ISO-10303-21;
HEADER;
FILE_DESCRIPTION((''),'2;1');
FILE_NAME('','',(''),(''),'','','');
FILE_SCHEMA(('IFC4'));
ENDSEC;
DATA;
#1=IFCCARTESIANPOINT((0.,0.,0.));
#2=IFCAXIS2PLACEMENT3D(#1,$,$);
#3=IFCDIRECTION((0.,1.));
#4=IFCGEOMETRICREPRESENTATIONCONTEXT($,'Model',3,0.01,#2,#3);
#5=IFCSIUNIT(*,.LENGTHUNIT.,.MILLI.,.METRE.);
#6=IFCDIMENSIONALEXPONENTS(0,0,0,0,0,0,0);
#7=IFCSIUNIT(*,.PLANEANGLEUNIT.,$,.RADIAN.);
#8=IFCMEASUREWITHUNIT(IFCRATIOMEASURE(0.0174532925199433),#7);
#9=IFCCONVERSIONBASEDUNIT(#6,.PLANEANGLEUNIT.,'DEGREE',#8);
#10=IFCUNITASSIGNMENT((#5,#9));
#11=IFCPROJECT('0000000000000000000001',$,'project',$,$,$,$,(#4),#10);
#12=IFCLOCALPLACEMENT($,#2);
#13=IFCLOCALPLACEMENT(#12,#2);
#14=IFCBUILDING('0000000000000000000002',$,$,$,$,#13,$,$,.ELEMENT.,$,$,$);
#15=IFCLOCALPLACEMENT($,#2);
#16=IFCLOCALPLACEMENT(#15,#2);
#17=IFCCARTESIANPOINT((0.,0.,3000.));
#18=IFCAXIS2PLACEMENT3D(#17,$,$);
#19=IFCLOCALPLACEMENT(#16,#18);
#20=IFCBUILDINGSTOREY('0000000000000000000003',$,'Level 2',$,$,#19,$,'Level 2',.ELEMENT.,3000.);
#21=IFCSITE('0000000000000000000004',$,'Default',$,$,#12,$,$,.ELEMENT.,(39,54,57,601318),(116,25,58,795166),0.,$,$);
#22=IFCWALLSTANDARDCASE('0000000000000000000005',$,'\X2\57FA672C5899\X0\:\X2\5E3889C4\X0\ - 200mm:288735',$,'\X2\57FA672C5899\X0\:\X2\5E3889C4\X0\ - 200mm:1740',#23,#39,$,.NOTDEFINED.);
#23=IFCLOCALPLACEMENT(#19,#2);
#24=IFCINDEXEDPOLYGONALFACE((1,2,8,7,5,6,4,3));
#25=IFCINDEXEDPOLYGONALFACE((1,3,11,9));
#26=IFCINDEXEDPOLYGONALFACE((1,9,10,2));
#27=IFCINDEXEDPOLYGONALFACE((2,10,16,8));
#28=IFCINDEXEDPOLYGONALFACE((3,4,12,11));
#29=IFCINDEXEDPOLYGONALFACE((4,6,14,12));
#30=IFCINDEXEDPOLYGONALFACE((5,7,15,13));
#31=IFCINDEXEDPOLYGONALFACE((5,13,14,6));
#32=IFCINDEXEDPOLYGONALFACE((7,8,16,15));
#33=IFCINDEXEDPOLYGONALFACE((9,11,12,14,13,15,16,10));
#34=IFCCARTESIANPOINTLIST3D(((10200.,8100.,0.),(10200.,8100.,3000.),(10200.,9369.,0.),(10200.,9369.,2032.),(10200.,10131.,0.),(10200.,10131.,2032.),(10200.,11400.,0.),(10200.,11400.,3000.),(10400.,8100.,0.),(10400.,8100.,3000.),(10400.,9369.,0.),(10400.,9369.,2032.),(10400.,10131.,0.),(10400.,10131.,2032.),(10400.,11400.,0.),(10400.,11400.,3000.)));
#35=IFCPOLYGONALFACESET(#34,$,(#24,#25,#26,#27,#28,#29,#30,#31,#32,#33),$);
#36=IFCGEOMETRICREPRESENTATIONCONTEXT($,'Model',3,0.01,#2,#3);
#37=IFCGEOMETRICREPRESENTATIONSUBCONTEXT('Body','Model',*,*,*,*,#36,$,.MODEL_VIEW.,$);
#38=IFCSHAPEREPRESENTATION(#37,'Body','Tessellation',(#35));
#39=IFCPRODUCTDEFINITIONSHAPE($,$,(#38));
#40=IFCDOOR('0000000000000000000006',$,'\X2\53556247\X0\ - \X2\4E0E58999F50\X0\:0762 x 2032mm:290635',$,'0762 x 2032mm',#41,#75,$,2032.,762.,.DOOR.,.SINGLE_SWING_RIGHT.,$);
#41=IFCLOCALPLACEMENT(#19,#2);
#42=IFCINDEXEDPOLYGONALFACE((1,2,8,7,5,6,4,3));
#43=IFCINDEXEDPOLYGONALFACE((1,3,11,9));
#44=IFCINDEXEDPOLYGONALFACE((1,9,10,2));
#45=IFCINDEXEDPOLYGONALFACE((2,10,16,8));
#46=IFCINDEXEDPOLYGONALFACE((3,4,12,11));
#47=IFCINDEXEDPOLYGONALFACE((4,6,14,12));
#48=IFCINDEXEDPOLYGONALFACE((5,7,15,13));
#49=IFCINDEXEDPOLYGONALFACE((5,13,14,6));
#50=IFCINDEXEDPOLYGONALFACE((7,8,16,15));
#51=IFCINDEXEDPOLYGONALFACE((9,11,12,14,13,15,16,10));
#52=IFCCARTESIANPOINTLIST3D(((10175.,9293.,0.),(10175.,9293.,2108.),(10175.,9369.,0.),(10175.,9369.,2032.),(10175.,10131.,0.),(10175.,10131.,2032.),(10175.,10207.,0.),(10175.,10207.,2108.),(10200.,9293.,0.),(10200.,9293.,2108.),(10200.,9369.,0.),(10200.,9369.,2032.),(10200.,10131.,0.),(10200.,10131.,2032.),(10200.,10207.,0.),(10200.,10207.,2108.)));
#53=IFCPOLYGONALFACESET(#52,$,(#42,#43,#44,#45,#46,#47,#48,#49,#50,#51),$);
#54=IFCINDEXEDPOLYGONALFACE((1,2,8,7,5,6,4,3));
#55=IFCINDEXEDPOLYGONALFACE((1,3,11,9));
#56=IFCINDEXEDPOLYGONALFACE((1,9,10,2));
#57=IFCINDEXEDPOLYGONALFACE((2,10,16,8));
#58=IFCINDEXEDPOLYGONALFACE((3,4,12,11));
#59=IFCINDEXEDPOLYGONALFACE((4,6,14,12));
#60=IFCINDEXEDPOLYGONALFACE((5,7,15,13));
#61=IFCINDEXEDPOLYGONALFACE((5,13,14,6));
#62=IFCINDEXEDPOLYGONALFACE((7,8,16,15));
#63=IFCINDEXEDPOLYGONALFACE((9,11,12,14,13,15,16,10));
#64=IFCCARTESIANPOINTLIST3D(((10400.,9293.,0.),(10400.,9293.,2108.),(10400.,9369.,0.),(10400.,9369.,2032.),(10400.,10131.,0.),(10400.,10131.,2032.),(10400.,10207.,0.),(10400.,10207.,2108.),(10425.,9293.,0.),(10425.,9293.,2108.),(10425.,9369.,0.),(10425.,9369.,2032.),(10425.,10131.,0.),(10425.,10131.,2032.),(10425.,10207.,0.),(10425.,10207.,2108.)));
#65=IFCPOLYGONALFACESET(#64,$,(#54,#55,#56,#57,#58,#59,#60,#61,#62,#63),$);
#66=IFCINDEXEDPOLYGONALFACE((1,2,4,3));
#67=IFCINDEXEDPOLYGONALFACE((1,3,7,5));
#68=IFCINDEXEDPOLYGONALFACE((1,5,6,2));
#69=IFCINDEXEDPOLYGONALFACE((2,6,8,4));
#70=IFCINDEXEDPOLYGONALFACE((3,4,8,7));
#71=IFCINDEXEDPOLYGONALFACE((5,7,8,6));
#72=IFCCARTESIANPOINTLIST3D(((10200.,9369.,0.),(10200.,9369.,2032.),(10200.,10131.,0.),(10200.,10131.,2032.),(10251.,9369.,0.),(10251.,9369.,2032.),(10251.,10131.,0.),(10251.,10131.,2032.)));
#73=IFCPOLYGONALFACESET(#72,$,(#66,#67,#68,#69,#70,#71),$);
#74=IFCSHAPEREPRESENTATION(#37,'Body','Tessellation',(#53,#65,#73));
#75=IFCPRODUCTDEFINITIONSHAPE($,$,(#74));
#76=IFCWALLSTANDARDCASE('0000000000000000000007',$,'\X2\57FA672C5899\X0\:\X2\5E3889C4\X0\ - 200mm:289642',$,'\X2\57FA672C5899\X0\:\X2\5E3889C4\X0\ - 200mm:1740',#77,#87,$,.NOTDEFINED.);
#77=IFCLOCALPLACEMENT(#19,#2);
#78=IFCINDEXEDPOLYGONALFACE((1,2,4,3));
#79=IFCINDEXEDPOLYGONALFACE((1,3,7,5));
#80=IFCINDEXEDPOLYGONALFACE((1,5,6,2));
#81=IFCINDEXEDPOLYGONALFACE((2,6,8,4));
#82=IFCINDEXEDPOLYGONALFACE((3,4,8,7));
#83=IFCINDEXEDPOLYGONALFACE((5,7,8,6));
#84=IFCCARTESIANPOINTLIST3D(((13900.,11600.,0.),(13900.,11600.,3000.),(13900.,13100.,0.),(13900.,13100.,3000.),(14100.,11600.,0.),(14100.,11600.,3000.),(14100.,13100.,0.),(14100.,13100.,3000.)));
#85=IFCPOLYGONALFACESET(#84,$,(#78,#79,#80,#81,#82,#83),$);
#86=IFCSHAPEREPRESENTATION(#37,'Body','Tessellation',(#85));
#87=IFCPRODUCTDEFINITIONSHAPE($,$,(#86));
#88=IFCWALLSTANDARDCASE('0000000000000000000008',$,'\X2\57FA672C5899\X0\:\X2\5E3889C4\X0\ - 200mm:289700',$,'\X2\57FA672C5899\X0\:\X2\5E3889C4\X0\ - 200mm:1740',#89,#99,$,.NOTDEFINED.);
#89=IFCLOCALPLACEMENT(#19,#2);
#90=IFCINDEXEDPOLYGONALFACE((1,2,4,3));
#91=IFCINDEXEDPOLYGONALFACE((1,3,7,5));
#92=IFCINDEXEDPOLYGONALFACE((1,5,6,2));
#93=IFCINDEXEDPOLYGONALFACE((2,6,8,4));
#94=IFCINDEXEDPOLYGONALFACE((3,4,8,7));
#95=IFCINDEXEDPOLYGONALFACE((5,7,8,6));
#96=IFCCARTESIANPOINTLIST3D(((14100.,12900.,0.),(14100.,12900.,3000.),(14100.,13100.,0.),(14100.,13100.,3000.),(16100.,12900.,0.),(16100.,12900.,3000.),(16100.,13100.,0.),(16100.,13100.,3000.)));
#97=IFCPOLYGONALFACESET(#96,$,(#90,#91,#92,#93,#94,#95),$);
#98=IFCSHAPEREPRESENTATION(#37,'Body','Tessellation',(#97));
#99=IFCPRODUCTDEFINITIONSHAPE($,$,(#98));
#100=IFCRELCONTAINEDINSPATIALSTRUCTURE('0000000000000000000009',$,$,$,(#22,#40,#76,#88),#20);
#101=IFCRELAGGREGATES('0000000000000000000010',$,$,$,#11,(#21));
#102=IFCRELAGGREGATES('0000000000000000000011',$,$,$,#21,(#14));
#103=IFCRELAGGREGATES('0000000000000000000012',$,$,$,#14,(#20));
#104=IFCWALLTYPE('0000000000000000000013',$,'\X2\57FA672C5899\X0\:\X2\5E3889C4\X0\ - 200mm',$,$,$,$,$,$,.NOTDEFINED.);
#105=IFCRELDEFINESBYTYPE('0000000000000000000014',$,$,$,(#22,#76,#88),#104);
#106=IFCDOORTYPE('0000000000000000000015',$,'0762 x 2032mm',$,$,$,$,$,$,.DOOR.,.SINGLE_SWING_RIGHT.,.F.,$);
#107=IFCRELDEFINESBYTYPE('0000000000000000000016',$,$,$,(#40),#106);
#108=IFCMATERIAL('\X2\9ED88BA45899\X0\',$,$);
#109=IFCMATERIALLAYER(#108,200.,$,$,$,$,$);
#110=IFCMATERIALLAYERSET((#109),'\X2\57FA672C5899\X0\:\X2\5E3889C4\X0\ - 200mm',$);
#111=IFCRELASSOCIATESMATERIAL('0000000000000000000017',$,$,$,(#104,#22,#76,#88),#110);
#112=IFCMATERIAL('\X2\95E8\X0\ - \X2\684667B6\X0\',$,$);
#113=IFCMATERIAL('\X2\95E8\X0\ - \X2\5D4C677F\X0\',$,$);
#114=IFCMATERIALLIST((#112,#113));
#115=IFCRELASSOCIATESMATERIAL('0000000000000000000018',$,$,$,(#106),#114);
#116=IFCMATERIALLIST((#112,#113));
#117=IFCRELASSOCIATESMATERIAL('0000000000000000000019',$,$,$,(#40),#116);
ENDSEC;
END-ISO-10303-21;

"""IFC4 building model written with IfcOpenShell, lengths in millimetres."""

from ifc_helpers import new_model, entity, si_unit, converted_unit, direction, frame, frame_2d, origin, place, context, subcontext, project, spatial, polyline, rectangle, outline, extrude, source, transform, mapped, material, material_list, layer, layer_set, layer_usage, type_object, type_shapes, element, fill, save


model = new_model("IFC4")

# Units and contexts
model_context_1 = context("Model", 3, precision=0.01, world=origin(), true_north=direction((0.0, 1.0)))
model_context_2 = context("Model", 3, precision=0.01, world=origin(), true_north=direction((0.0, 1.0)))
body_context = subcontext(model_context_2, "Body", "Model", "MODEL_VIEW")
ifc_project = project(units=[si_unit("LENGTHUNIT", "METRE", prefix="MILLI"), converted_unit("PLANEANGLEUNIT", "DEGREE", entity("IfcRatioMeasure", 0.0174532925199433), si_unit("PLANEANGLEUNIT", "RADIAN"), dimensions=[0, 0, 0, 0, 0, 0, 0])], contexts=[model_context_1])

# Site, building, storey
site_placement = place(None, origin())
site = spatial("IfcSite", under=ifc_project, at=site_placement, Name="Default", CompositionType="ELEMENT", RefLatitude=(39, 54, 57, 601318), RefLongitude=(116, 25, 58, 795166), RefElevation=0.0)
building_placement = place(site_placement, origin())
building = spatial("IfcBuilding", under=site, at=building_placement, CompositionType="ELEMENT")
placement_1 = place(None, origin())
placement_2 = place(placement_1, origin())
storey_placement = place(placement_2, frame((0.0, 0.0, 3000.0)))
storey = spatial("IfcBuildingStorey", under=building, at=storey_placement, Name="Level 2", LongName="Level 2", CompositionType="ELEMENT", Elevation=3000.0)

# Shared definitions
ifc_material_1 = material(Name="默认墙")
ifc_layer = layer(ifc_material_1, 200.0)
ifc_layer_set = layer_set([ifc_layer], Name="基本墙:常规 - 200mm")
wall_type = type_object("IfcWallType", Name="基本墙:常规 - 200mm", PredefinedType="NOTDEFINED", material=ifc_layer_set)

# Wall, opening, door
ifc_layer_usage_1 = layer_usage(ifc_layer_set, "AXIS2", "NEGATIVE", 100.0)
wall_1_placement = place(storey_placement, frame((10300.0, 11400.0, 0.0), z_axis=(0.0, 0.0, 1.0), x_axis=(0.0, -1.0, 0.0)))
wall_1 = element("IfcWallStandardCase", 1, at=wall_1_placement, inside=storey, type_object=wall_type, material=ifc_layer_usage_1, Name="基本墙:常规 - 200mm:288735", ObjectType="基本墙:常规 - 200mm:1740", PredefinedType="NOTDEFINED", context=body_context, shape_type="SweptSolid", body=[
    extrude(rectangle(XDim=3300.0, YDim=200.0, at=frame_2d((1650.0, 0.0), x_axis=(-1.0, 0.0))), origin(), (0.0, 0.0, 1.0), 3000.0),
])
opening_1_placement = place(wall_1_placement, frame((2031.0, 100.0, 0.0)))
opening_1 = element("IfcOpeningElement", 2, at=opening_1_placement, cuts=wall_1, ObjectType="Opening", PredefinedType="OPENING", context=body_context, shape_type="SweptSolid", body=[
    extrude(rectangle(XDim=762.0, YDim=2032.0, at=frame_2d((1016.0, 381.0), x_axis=(0.0, 1.0))), frame((0.0, 0.0, 0.0), z_axis=(0.0, -1.0, 0.0), x_axis=(0.0, 0.0, 1.0)), (0.0, 0.0, 1.0), 200.0),
])
ifc_material_2 = material(Name="门 - 框架")
ifc_material_3 = material(Name="门 - 嵌板")
ifc_material_list_1 = material_list([ifc_material_2, ifc_material_3])
ifc_material_list_2 = material_list([ifc_material_2, ifc_material_3])
door_type_1 = type_object("IfcDoorType", Name="0762 x 2032mm", OperationType="SINGLE_SWING_RIGHT", ParameterTakesPrecedence=False, PredefinedType="DOOR", material=ifc_material_list_2)
shared_shape_1 = source(origin(), body_context, "Body", "SweptSolid", [
    extrude(outline(polyline([(-457.0, -1073.0), (457.0, -1073.0), (457.0, 1035.0), (381.0, 1035.0), (381.0, -997.0), (-381.0, -997.0), (-381.0, 1035.0), (-457.0, 1035.0), (-457.0, -1073.0)])), frame((381.0, 200.0, 1035.0), z_axis=(0.0, 1.0, 0.0), x_axis=(1.0, 0.0, 0.0)), (0.0, 0.0, 1.0), 25.0),
    extrude(outline(polyline([(-1073.0, -457.0), (1035.0, -457.0), (1035.0, -381.0), (-997.0, -381.0), (-997.0, 381.0), (1035.0, 381.0), (1035.0, 457.0), (-1073.0, 457.0), (-1073.0, -457.0)])), frame((381.0, -25.0, 1035.0), z_axis=(0.0, 1.0, 0.0), x_axis=(0.0, 0.0, -1.0)), (0.0, 0.0, 1.0), 25.0),
    extrude(rectangle(XDim=51.0, YDim=762.0, at=frame_2d((0.0, 0.0), x_axis=(1.0, 0.0))), frame((381.0, 174.5, 0.0), z_axis=(0.0, 0.0, 1.0), x_axis=(0.0, 1.0, 0.0)), (0.0, 0.0, 1.0), 2032.0),
])
type_shapes(door_type_1, [shared_shape_1])
door_1_placement = place(opening_1_placement, frame((0.0, 0.0, 0.0), z_axis=(0.0, 0.0, 1.0), x_axis=(-1.0, 0.0, 0.0)))
door_1 = element("IfcDoor", 3, at=door_1_placement, inside=storey, type_object=door_type_1, material=ifc_material_list_1, Name="单扇 - 与墙齐:0762 x 2032mm:290635", ObjectType="0762 x 2032mm", OperationType="SINGLE_SWING_RIGHT", OverallHeight=2032.0, OverallWidth=762.0, PredefinedType="DOOR", context=body_context, shape_type="MappedRepresentation", body=[
    mapped(shared_shape_1, transform((0.0, 0.0, 0.0), scale=1.0)),
])
fill(opening_1, door_1)

# Walls
ifc_layer_usage_2 = layer_usage(ifc_layer_set, "AXIS2", "NEGATIVE", 100.0)
wall_2_placement = place(storey_placement, frame((14000.0, 11600.0, 0.0), z_axis=(0.0, 0.0, 1.0), x_axis=(0.0, 1.0, 0.0)))
element("IfcWallStandardCase", 4, at=wall_2_placement, inside=storey, type_object=wall_type, material=ifc_layer_usage_2, Name="基本墙:常规 - 200mm:289642", ObjectType="基本墙:常规 - 200mm:1740", PredefinedType="NOTDEFINED", context=body_context, shape_type="SweptSolid", body=[
    extrude(rectangle(XDim=1500.0, YDim=200.0, at=frame_2d((750.0, 0.0), x_axis=(-1.0, 0.0))), origin(), (0.0, 0.0, 1.0), 3000.0),
])
ifc_layer_usage_3 = layer_usage(ifc_layer_set, "AXIS2", "NEGATIVE", 100.0)
wall_3_placement = place(storey_placement, frame((14100.0, 13000.0, 0.0)))
element("IfcWallStandardCase", 5, at=wall_3_placement, inside=storey, type_object=wall_type, material=ifc_layer_usage_3, Name="基本墙:常规 - 200mm:289700", ObjectType="基本墙:常规 - 200mm:1740", PredefinedType="NOTDEFINED", context=body_context, shape_type="SweptSolid", body=[
    extrude(rectangle(XDim=2000.0, YDim=200.0, at=frame_2d((1000.0, 0.0), x_axis=(-1.0, 0.0))), origin(), (0.0, 0.0, 1.0), 3000.0),
])

save(model, "model.ifc")
